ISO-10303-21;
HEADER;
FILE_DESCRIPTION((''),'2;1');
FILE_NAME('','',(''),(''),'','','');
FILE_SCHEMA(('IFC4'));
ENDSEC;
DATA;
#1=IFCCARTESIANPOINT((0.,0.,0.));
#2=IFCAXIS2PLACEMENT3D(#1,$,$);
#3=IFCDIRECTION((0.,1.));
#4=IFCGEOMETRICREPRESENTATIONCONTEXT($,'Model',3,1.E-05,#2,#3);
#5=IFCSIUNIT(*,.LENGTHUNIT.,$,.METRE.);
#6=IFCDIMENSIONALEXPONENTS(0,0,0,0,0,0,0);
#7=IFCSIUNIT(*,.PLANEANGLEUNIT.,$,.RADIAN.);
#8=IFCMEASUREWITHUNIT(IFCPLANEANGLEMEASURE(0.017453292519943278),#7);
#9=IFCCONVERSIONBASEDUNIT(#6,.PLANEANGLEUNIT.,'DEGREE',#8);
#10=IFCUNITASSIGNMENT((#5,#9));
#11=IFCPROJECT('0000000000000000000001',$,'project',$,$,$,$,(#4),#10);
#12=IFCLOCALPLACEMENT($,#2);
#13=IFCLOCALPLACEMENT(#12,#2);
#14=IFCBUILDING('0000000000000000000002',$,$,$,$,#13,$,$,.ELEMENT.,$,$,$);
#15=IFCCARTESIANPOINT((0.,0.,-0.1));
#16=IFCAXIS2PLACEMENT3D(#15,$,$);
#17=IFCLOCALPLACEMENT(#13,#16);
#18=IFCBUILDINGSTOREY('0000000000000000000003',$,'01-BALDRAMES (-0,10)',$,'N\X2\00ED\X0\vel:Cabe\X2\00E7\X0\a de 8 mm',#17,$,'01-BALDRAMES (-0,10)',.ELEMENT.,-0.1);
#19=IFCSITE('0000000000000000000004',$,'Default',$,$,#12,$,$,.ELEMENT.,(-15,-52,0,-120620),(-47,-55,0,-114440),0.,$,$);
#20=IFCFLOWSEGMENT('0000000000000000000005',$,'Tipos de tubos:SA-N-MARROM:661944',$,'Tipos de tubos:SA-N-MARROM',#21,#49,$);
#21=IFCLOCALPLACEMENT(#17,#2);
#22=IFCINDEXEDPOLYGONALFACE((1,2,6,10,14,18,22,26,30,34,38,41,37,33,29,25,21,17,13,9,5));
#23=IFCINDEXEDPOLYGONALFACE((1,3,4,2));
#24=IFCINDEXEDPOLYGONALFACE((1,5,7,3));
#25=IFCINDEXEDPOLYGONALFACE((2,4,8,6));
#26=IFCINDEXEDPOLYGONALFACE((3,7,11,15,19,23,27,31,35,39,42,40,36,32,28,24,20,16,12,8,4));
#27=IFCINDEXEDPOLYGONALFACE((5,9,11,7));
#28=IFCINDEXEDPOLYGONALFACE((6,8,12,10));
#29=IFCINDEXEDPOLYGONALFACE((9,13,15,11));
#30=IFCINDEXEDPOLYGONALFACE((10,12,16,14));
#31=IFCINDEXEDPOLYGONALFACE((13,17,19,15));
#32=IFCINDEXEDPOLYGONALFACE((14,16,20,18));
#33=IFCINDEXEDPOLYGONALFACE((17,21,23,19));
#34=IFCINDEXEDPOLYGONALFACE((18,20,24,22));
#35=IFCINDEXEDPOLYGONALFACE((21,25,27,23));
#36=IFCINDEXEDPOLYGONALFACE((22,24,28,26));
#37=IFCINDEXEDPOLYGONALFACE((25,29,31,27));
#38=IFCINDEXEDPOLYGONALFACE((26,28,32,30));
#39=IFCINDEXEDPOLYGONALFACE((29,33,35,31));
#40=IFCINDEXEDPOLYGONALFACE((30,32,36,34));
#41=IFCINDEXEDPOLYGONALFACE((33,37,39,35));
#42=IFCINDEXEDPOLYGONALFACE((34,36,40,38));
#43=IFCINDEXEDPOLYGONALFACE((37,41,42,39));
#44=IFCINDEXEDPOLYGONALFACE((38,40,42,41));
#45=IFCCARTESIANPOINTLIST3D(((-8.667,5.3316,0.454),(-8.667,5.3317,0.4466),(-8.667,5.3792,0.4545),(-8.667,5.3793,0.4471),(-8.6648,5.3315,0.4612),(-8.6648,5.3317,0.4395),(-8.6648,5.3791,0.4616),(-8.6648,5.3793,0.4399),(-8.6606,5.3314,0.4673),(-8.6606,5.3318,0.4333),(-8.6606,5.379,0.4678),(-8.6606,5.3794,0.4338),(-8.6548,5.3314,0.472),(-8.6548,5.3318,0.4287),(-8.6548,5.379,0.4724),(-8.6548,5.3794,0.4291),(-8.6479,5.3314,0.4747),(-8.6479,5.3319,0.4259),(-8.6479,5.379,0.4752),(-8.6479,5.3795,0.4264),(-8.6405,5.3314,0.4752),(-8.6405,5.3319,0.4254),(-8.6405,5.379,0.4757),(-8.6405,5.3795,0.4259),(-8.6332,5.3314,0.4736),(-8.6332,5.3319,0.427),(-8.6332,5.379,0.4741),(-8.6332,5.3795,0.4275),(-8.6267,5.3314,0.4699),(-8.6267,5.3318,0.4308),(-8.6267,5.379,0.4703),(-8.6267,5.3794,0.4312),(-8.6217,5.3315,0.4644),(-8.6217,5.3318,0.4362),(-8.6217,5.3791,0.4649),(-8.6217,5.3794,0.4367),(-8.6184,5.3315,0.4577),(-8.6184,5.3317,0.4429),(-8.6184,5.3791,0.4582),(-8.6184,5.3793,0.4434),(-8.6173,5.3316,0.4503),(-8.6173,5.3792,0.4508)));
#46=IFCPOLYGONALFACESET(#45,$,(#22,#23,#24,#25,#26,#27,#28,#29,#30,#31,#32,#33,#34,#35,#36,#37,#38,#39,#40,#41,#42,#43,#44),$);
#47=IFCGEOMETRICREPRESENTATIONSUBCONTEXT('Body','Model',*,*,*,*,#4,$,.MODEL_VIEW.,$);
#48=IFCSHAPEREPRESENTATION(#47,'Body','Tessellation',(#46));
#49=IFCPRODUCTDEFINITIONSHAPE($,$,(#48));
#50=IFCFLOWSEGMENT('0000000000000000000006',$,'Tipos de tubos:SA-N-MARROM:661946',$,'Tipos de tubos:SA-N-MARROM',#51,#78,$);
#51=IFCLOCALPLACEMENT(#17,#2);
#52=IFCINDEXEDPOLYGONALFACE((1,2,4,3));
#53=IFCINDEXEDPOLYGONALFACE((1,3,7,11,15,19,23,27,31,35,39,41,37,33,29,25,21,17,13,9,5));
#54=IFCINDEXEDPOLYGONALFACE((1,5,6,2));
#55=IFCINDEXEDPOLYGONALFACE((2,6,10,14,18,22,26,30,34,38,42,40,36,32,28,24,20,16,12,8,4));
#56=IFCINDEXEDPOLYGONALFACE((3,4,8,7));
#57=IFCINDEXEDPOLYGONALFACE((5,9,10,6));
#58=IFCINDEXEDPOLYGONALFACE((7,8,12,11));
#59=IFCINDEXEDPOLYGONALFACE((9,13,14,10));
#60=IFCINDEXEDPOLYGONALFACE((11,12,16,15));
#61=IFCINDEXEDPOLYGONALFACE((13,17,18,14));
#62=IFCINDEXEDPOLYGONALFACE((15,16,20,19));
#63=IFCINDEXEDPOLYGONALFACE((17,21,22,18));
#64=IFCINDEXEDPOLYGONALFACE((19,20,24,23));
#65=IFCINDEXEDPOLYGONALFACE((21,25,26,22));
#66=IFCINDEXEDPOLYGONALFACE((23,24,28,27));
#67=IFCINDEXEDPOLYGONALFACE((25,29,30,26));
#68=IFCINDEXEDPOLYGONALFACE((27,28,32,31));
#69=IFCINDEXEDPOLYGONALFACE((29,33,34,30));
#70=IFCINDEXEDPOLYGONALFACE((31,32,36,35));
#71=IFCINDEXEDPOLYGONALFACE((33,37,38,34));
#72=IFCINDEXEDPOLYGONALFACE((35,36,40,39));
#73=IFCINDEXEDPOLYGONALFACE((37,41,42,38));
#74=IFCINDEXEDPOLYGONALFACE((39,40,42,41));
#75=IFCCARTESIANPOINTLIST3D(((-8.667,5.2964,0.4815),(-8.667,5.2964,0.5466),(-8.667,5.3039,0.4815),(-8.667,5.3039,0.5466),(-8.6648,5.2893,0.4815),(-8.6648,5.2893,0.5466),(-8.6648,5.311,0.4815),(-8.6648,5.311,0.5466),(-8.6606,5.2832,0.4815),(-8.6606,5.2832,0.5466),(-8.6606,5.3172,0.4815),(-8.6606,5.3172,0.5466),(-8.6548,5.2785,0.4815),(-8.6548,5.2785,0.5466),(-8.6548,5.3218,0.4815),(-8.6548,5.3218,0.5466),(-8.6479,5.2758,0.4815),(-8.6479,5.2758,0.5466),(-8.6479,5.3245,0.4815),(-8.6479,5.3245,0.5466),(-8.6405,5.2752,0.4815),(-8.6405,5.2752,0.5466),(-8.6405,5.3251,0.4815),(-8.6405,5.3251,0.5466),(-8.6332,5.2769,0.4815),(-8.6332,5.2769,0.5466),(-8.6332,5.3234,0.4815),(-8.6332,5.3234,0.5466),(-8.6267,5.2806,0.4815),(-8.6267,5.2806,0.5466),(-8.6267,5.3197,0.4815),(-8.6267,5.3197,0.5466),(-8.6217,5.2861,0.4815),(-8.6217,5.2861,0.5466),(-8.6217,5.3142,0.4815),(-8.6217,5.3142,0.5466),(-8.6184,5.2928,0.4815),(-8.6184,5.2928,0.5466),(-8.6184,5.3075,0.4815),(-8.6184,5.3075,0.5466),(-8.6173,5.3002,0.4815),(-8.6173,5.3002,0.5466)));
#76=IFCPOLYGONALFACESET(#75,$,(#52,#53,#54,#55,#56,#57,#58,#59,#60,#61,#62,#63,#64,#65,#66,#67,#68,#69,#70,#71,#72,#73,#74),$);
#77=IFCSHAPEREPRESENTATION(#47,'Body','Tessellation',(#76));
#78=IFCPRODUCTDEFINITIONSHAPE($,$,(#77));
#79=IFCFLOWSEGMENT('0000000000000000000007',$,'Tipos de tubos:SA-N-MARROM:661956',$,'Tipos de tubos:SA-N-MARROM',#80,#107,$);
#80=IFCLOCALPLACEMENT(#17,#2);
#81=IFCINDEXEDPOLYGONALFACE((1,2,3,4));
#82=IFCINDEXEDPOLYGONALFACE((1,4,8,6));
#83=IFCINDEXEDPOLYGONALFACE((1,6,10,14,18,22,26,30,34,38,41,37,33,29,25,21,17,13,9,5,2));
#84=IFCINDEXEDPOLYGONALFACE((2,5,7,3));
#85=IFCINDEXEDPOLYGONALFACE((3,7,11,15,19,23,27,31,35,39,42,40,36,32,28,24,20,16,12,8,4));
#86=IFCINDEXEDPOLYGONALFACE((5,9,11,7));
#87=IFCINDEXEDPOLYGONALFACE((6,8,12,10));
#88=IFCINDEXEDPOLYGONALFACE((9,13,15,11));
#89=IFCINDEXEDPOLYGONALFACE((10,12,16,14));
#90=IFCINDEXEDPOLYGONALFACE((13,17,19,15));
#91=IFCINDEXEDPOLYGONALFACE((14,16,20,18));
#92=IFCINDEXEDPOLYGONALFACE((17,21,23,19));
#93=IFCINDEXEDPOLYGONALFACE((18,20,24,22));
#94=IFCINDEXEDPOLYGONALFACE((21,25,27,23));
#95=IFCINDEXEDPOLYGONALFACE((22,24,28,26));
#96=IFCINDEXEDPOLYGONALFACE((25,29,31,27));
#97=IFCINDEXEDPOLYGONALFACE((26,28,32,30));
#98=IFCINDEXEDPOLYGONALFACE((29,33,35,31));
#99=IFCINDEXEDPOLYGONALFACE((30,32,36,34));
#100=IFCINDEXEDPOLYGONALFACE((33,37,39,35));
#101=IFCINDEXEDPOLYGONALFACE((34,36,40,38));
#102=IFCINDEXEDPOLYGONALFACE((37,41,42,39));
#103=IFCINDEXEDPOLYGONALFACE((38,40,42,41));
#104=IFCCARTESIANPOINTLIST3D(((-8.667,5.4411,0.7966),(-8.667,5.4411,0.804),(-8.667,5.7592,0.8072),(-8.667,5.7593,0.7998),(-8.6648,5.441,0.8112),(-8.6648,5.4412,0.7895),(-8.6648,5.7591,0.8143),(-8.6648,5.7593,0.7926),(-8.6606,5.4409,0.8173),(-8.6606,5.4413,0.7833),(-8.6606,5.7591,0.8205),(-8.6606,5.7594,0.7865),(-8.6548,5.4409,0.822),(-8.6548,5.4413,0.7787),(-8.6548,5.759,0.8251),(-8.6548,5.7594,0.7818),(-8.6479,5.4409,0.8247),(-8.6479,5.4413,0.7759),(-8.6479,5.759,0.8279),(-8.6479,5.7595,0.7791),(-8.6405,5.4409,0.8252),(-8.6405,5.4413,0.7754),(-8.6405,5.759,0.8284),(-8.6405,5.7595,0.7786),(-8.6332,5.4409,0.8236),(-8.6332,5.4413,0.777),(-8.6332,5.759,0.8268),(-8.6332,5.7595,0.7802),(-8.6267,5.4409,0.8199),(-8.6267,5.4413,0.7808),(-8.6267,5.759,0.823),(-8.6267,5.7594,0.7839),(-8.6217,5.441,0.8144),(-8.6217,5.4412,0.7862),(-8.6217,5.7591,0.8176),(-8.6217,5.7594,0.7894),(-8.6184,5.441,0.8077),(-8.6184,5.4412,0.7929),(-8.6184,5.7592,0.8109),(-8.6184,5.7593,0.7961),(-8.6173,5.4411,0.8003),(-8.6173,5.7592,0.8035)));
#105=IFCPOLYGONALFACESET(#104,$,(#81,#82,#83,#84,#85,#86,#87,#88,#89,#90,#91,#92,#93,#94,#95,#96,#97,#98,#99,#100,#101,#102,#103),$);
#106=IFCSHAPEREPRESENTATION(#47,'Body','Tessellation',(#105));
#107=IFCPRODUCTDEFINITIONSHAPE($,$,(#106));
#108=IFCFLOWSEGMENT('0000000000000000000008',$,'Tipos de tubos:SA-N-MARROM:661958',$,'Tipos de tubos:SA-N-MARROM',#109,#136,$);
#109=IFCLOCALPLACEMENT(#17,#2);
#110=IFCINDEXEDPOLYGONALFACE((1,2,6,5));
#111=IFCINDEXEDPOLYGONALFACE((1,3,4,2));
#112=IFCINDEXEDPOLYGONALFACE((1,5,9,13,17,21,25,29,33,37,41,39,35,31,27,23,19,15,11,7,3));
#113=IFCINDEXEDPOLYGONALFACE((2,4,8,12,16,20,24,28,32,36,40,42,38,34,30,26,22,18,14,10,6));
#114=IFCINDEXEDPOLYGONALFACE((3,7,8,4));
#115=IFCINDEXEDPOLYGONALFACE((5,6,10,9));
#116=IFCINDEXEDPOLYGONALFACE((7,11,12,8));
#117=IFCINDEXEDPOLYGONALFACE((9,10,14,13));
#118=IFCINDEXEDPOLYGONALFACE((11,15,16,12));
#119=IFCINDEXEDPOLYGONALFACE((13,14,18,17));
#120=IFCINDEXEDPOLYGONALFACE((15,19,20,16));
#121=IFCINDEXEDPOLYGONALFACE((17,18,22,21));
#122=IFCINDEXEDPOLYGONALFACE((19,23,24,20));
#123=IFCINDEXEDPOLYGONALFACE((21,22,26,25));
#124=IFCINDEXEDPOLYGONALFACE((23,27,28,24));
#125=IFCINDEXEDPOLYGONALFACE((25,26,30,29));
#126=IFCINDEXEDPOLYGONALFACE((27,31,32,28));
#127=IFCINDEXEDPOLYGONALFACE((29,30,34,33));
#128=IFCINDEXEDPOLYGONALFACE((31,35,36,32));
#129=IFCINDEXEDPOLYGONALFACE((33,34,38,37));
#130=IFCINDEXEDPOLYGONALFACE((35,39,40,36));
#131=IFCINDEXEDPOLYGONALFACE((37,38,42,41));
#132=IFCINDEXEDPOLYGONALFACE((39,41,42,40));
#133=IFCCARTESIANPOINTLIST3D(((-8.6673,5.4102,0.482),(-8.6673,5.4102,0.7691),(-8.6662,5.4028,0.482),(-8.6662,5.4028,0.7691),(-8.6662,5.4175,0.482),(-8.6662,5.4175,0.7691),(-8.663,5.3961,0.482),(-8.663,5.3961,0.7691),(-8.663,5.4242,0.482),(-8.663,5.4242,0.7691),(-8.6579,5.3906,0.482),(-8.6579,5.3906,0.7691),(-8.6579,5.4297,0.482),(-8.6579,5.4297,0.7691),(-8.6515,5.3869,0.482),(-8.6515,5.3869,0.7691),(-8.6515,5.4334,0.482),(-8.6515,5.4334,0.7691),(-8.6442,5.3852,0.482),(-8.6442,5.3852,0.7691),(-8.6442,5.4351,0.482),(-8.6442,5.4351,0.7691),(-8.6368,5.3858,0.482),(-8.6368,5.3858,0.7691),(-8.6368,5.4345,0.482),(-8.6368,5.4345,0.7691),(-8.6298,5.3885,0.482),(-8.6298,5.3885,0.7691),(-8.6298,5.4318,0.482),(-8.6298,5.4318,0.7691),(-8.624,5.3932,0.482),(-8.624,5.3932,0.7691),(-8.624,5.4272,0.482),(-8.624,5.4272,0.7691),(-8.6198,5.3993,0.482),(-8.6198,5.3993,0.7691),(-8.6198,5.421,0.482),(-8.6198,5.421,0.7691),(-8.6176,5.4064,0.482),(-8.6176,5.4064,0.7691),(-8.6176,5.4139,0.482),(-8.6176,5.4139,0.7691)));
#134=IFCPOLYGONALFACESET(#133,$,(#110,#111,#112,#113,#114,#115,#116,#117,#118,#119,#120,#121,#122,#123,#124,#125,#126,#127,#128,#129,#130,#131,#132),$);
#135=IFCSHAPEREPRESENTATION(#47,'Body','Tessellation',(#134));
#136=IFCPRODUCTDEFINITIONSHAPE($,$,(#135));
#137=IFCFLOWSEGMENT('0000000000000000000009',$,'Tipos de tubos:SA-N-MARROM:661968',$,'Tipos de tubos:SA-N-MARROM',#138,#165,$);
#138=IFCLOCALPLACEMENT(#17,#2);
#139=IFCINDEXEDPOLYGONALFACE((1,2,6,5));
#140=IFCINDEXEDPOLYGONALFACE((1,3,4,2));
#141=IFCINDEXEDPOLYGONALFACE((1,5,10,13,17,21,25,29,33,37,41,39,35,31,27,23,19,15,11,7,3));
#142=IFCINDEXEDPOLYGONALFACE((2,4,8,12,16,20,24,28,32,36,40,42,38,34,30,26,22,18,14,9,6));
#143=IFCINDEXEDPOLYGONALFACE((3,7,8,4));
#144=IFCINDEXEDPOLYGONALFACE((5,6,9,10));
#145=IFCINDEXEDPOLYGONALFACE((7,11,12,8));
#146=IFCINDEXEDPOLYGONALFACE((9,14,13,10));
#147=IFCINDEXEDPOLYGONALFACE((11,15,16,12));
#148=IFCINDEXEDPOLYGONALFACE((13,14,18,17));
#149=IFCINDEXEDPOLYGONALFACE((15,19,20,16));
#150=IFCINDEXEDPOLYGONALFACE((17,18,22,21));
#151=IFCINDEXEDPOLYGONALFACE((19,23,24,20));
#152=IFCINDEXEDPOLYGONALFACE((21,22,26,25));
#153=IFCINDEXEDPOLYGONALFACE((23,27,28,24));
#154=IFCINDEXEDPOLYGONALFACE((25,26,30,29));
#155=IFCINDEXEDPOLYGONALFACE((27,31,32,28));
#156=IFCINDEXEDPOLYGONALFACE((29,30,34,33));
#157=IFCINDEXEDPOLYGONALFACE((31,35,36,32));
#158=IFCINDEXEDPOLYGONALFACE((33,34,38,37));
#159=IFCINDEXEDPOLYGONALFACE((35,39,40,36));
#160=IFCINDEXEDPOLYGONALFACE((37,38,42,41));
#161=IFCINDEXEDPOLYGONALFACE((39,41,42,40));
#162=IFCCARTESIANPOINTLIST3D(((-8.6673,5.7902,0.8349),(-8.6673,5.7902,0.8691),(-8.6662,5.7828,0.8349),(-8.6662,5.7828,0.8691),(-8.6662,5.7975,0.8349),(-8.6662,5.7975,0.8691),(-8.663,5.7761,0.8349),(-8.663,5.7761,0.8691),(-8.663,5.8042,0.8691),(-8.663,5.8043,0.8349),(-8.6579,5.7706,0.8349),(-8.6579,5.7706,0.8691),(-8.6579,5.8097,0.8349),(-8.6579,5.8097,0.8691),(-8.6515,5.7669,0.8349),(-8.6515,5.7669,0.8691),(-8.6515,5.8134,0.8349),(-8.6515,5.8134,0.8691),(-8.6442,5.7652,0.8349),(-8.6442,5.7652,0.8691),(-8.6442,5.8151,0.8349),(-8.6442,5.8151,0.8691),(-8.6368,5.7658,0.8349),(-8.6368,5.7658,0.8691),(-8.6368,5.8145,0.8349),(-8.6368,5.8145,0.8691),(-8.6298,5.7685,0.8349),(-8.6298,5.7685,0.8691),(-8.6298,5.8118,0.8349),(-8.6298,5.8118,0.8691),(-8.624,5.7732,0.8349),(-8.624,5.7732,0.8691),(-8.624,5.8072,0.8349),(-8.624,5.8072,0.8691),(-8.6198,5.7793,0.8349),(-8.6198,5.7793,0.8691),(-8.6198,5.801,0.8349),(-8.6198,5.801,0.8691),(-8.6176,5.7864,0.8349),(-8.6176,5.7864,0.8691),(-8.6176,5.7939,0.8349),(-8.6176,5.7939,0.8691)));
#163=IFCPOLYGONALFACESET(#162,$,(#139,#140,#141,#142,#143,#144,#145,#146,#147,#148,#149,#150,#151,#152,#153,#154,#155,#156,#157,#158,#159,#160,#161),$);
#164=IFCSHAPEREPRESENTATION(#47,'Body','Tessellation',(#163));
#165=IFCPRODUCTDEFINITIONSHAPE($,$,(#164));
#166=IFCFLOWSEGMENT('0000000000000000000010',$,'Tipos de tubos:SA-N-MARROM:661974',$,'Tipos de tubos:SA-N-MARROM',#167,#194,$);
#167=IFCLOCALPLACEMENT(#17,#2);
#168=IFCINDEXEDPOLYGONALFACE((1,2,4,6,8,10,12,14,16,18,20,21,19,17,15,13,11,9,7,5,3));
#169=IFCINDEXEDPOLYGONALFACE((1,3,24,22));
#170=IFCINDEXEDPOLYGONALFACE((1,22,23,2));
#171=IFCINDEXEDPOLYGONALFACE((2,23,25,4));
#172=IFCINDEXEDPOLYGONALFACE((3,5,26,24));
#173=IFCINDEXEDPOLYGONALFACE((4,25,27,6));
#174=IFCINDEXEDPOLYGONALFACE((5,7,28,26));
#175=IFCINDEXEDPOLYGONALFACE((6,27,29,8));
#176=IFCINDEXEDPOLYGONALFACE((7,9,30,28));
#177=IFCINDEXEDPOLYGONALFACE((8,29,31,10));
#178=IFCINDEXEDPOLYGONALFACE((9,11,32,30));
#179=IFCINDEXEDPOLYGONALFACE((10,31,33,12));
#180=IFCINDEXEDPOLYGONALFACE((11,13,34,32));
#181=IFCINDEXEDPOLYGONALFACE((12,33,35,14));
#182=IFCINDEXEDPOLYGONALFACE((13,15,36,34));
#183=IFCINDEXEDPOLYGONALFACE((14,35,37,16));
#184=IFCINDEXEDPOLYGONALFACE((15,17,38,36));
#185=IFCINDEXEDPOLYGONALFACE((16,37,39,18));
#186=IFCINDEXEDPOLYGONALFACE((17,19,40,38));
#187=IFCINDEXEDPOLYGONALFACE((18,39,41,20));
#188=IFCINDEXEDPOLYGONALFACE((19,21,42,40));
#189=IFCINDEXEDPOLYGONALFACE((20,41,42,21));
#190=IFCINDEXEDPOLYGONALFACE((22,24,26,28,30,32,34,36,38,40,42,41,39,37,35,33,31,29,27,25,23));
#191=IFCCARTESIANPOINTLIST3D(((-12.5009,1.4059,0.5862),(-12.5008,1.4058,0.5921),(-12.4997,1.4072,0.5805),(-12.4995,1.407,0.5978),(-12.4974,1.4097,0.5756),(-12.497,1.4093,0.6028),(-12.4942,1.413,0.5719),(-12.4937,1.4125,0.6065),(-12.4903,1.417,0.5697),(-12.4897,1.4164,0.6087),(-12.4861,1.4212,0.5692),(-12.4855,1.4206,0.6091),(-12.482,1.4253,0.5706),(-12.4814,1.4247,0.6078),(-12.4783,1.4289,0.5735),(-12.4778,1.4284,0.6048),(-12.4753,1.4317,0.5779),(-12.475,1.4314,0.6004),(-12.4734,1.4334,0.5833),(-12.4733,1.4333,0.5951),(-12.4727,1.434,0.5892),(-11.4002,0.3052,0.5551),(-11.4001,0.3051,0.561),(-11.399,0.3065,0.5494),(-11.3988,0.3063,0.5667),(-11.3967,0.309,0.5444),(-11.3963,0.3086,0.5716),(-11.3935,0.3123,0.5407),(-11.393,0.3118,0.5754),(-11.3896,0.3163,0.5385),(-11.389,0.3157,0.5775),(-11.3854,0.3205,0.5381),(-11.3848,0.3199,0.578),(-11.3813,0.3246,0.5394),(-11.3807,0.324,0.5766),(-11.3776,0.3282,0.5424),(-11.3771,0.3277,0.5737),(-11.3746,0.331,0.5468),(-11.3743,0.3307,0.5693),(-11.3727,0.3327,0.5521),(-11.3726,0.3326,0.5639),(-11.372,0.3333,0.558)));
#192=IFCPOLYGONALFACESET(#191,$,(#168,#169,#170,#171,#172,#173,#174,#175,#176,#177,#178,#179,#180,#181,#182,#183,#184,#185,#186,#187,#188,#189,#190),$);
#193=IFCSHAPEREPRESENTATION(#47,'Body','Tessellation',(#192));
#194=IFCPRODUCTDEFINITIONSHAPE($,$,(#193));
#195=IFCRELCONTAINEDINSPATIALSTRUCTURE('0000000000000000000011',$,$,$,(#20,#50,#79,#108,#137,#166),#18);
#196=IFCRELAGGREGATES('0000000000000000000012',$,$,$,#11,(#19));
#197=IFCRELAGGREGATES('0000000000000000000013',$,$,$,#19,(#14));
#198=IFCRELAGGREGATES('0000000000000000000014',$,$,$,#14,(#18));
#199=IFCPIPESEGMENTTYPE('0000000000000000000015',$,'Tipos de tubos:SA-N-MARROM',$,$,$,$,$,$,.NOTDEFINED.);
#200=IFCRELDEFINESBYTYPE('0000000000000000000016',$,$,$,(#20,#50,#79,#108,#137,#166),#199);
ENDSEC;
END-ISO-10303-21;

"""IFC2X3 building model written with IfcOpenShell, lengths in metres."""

from ifc_helpers import new_model, entity, si_unit, converted_unit, direction, frame, frame_2d, origin, origin_2d_with_axis, place, context, subcontext, project, spatial, circle, extrude, type_object, element, save


model = new_model("IFC2X3")

# Units and contexts
model_context = context("Model", 3, precision=1e-05, world=origin(), true_north=direction((0.0, 1.0)))
body_context = subcontext(model_context, "Body", "Model", "MODEL_VIEW")
ifc_project = project(units=[si_unit("LENGTHUNIT", "METRE"), converted_unit("PLANEANGLEUNIT", "DEGREE", entity("IfcPlaneAngleMeasure", 0.017453292519943278), si_unit("PLANEANGLEUNIT", "RADIAN"), dimensions=[0, 0, 0, 0, 0, 0, 0])], contexts=[model_context])

# Site, building, storey
site_placement = place(None, origin())
site = spatial("IfcSite", under=ifc_project, at=site_placement, Name="Default", CompositionType="ELEMENT", RefLatitude=(-15, -52, 0, -120620), RefLongitude=(-47, -55, 0, -114440), RefElevation=0.0)
building_placement = place(site_placement, origin())
building = spatial("IfcBuilding", under=site, at=building_placement, CompositionType="ELEMENT")
storey_placement = place(building_placement, frame((0.0, 0.0, -0.1)))
storey = spatial("IfcBuildingStorey", under=building, at=storey_placement, Name="01-BALDRAMES (-0,10)", ObjectType="Nível:Cabeça de 8 mm", LongName="01-BALDRAMES (-0,10)", CompositionType="ELEMENT", Elevation=-0.1)

# Flow segments
pipe_segment_type_1 = type_object("IfcPipeSegmentType", Name="Tipos de tubos:SA-N-MARROM", PredefinedType="NOTDEFINED")
flow_segment_1_placement = place(storey_placement, origin())
element("IfcFlowSegment", 1, at=flow_segment_1_placement, inside=storey, type_object=pipe_segment_type_1, Name="Tipos de tubos:SA-N-MARROM:661944", ObjectType="Tipos de tubos:SA-N-MARROM", context=body_context, shape_type="SweptSolid", body=[
    extrude(circle(Radius=0.025, at=frame_2d((0.0, 0.0), x_axis=(1.0, 0.0))), frame((-8.6423, 5.3316, 0.4503), z_axis=(-0.000001, 0.99995, 0.01), x_axis=(1.0, 0.000001, 0.0)), (0.0, 0.0, 1.0), 0.0476),
])
flow_segment_2_placement = place(storey_placement, origin())
element("IfcFlowSegment", 2, at=flow_segment_2_placement, inside=storey, type_object=pipe_segment_type_1, Name="Tipos de tubos:SA-N-MARROM:661946", ObjectType="Tipos de tubos:SA-N-MARROM", context=body_context, shape_type="SweptSolid", body=[
    extrude(circle(Radius=0.025, at=origin_2d_with_axis()), frame((-8.6423, 5.3002, 0.4815)), (0.0, 0.0, 1.0), 0.0651),
])
flow_segment_3_placement = place(storey_placement, origin())
element("IfcFlowSegment", 3, at=flow_segment_3_placement, inside=storey, type_object=pipe_segment_type_1, Name="Tipos de tubos:SA-N-MARROM:661956", ObjectType="Tipos de tubos:SA-N-MARROM", context=body_context, shape_type="SweptSolid", body=[
    extrude(circle(Radius=0.025, at=frame_2d((0.0, 0.0), x_axis=(1.0, 0.0))), frame((-8.6423, 5.4411, 0.8003), z_axis=(-0.000001, 0.99995, 0.01), x_axis=(1.0, 0.000001, 0.0)), (0.0, 0.0, 1.0), 0.3181),
])
flow_segment_4_placement = place(storey_placement, origin())
element("IfcFlowSegment", 4, at=flow_segment_4_placement, inside=storey, type_object=pipe_segment_type_1, Name="Tipos de tubos:SA-N-MARROM:661958", ObjectType="Tipos de tubos:SA-N-MARROM", context=body_context, shape_type="SweptSolid", body=[
    extrude(circle(Radius=0.025, at=origin_2d_with_axis()), frame((-8.6423, 5.4102, 0.482), z_axis=(0.0, 0.0, 1.0), x_axis=(-1.0, 0.0, 0.0)), (0.0, 0.0, 1.0), 0.287),
])
flow_segment_5_placement = place(storey_placement, origin())
element("IfcFlowSegment", 5, at=flow_segment_5_placement, inside=storey, type_object=pipe_segment_type_1, Name="Tipos de tubos:SA-N-MARROM:661968", ObjectType="Tipos de tubos:SA-N-MARROM", context=body_context, shape_type="SweptSolid", body=[
    extrude(circle(Radius=0.025, at=origin_2d_with_axis()), frame((-8.6423, 5.7902, 0.8349), z_axis=(0.0, -0.000234, 1.0), x_axis=(-1.0, 0.0, 0.0)), (0.0, 0.0, 1.0), 0.0341),
])
flow_segment_6_placement = place(storey_placement, origin())
element("IfcFlowSegment", 6, at=flow_segment_6_placement, inside=storey, type_object=pipe_segment_type_1, Name="Tipos de tubos:SA-N-MARROM:661974", ObjectType="Tipos de tubos:SA-N-MARROM", context=body_context, shape_type="SweptSolid", body=[
    extrude(circle(Radius=0.02, at=frame_2d((0.0, 0.0), x_axis=(1.0, 0.0))), frame((-12.4869, 1.4198, 0.5892), z_axis=(0.706966, -0.706965, -0.019996), x_axis=(0.707106, 0.707107, 0.0)), (0.0, 0.0, 1.0), 1.5569),
])

save(model, "model.ifc")
